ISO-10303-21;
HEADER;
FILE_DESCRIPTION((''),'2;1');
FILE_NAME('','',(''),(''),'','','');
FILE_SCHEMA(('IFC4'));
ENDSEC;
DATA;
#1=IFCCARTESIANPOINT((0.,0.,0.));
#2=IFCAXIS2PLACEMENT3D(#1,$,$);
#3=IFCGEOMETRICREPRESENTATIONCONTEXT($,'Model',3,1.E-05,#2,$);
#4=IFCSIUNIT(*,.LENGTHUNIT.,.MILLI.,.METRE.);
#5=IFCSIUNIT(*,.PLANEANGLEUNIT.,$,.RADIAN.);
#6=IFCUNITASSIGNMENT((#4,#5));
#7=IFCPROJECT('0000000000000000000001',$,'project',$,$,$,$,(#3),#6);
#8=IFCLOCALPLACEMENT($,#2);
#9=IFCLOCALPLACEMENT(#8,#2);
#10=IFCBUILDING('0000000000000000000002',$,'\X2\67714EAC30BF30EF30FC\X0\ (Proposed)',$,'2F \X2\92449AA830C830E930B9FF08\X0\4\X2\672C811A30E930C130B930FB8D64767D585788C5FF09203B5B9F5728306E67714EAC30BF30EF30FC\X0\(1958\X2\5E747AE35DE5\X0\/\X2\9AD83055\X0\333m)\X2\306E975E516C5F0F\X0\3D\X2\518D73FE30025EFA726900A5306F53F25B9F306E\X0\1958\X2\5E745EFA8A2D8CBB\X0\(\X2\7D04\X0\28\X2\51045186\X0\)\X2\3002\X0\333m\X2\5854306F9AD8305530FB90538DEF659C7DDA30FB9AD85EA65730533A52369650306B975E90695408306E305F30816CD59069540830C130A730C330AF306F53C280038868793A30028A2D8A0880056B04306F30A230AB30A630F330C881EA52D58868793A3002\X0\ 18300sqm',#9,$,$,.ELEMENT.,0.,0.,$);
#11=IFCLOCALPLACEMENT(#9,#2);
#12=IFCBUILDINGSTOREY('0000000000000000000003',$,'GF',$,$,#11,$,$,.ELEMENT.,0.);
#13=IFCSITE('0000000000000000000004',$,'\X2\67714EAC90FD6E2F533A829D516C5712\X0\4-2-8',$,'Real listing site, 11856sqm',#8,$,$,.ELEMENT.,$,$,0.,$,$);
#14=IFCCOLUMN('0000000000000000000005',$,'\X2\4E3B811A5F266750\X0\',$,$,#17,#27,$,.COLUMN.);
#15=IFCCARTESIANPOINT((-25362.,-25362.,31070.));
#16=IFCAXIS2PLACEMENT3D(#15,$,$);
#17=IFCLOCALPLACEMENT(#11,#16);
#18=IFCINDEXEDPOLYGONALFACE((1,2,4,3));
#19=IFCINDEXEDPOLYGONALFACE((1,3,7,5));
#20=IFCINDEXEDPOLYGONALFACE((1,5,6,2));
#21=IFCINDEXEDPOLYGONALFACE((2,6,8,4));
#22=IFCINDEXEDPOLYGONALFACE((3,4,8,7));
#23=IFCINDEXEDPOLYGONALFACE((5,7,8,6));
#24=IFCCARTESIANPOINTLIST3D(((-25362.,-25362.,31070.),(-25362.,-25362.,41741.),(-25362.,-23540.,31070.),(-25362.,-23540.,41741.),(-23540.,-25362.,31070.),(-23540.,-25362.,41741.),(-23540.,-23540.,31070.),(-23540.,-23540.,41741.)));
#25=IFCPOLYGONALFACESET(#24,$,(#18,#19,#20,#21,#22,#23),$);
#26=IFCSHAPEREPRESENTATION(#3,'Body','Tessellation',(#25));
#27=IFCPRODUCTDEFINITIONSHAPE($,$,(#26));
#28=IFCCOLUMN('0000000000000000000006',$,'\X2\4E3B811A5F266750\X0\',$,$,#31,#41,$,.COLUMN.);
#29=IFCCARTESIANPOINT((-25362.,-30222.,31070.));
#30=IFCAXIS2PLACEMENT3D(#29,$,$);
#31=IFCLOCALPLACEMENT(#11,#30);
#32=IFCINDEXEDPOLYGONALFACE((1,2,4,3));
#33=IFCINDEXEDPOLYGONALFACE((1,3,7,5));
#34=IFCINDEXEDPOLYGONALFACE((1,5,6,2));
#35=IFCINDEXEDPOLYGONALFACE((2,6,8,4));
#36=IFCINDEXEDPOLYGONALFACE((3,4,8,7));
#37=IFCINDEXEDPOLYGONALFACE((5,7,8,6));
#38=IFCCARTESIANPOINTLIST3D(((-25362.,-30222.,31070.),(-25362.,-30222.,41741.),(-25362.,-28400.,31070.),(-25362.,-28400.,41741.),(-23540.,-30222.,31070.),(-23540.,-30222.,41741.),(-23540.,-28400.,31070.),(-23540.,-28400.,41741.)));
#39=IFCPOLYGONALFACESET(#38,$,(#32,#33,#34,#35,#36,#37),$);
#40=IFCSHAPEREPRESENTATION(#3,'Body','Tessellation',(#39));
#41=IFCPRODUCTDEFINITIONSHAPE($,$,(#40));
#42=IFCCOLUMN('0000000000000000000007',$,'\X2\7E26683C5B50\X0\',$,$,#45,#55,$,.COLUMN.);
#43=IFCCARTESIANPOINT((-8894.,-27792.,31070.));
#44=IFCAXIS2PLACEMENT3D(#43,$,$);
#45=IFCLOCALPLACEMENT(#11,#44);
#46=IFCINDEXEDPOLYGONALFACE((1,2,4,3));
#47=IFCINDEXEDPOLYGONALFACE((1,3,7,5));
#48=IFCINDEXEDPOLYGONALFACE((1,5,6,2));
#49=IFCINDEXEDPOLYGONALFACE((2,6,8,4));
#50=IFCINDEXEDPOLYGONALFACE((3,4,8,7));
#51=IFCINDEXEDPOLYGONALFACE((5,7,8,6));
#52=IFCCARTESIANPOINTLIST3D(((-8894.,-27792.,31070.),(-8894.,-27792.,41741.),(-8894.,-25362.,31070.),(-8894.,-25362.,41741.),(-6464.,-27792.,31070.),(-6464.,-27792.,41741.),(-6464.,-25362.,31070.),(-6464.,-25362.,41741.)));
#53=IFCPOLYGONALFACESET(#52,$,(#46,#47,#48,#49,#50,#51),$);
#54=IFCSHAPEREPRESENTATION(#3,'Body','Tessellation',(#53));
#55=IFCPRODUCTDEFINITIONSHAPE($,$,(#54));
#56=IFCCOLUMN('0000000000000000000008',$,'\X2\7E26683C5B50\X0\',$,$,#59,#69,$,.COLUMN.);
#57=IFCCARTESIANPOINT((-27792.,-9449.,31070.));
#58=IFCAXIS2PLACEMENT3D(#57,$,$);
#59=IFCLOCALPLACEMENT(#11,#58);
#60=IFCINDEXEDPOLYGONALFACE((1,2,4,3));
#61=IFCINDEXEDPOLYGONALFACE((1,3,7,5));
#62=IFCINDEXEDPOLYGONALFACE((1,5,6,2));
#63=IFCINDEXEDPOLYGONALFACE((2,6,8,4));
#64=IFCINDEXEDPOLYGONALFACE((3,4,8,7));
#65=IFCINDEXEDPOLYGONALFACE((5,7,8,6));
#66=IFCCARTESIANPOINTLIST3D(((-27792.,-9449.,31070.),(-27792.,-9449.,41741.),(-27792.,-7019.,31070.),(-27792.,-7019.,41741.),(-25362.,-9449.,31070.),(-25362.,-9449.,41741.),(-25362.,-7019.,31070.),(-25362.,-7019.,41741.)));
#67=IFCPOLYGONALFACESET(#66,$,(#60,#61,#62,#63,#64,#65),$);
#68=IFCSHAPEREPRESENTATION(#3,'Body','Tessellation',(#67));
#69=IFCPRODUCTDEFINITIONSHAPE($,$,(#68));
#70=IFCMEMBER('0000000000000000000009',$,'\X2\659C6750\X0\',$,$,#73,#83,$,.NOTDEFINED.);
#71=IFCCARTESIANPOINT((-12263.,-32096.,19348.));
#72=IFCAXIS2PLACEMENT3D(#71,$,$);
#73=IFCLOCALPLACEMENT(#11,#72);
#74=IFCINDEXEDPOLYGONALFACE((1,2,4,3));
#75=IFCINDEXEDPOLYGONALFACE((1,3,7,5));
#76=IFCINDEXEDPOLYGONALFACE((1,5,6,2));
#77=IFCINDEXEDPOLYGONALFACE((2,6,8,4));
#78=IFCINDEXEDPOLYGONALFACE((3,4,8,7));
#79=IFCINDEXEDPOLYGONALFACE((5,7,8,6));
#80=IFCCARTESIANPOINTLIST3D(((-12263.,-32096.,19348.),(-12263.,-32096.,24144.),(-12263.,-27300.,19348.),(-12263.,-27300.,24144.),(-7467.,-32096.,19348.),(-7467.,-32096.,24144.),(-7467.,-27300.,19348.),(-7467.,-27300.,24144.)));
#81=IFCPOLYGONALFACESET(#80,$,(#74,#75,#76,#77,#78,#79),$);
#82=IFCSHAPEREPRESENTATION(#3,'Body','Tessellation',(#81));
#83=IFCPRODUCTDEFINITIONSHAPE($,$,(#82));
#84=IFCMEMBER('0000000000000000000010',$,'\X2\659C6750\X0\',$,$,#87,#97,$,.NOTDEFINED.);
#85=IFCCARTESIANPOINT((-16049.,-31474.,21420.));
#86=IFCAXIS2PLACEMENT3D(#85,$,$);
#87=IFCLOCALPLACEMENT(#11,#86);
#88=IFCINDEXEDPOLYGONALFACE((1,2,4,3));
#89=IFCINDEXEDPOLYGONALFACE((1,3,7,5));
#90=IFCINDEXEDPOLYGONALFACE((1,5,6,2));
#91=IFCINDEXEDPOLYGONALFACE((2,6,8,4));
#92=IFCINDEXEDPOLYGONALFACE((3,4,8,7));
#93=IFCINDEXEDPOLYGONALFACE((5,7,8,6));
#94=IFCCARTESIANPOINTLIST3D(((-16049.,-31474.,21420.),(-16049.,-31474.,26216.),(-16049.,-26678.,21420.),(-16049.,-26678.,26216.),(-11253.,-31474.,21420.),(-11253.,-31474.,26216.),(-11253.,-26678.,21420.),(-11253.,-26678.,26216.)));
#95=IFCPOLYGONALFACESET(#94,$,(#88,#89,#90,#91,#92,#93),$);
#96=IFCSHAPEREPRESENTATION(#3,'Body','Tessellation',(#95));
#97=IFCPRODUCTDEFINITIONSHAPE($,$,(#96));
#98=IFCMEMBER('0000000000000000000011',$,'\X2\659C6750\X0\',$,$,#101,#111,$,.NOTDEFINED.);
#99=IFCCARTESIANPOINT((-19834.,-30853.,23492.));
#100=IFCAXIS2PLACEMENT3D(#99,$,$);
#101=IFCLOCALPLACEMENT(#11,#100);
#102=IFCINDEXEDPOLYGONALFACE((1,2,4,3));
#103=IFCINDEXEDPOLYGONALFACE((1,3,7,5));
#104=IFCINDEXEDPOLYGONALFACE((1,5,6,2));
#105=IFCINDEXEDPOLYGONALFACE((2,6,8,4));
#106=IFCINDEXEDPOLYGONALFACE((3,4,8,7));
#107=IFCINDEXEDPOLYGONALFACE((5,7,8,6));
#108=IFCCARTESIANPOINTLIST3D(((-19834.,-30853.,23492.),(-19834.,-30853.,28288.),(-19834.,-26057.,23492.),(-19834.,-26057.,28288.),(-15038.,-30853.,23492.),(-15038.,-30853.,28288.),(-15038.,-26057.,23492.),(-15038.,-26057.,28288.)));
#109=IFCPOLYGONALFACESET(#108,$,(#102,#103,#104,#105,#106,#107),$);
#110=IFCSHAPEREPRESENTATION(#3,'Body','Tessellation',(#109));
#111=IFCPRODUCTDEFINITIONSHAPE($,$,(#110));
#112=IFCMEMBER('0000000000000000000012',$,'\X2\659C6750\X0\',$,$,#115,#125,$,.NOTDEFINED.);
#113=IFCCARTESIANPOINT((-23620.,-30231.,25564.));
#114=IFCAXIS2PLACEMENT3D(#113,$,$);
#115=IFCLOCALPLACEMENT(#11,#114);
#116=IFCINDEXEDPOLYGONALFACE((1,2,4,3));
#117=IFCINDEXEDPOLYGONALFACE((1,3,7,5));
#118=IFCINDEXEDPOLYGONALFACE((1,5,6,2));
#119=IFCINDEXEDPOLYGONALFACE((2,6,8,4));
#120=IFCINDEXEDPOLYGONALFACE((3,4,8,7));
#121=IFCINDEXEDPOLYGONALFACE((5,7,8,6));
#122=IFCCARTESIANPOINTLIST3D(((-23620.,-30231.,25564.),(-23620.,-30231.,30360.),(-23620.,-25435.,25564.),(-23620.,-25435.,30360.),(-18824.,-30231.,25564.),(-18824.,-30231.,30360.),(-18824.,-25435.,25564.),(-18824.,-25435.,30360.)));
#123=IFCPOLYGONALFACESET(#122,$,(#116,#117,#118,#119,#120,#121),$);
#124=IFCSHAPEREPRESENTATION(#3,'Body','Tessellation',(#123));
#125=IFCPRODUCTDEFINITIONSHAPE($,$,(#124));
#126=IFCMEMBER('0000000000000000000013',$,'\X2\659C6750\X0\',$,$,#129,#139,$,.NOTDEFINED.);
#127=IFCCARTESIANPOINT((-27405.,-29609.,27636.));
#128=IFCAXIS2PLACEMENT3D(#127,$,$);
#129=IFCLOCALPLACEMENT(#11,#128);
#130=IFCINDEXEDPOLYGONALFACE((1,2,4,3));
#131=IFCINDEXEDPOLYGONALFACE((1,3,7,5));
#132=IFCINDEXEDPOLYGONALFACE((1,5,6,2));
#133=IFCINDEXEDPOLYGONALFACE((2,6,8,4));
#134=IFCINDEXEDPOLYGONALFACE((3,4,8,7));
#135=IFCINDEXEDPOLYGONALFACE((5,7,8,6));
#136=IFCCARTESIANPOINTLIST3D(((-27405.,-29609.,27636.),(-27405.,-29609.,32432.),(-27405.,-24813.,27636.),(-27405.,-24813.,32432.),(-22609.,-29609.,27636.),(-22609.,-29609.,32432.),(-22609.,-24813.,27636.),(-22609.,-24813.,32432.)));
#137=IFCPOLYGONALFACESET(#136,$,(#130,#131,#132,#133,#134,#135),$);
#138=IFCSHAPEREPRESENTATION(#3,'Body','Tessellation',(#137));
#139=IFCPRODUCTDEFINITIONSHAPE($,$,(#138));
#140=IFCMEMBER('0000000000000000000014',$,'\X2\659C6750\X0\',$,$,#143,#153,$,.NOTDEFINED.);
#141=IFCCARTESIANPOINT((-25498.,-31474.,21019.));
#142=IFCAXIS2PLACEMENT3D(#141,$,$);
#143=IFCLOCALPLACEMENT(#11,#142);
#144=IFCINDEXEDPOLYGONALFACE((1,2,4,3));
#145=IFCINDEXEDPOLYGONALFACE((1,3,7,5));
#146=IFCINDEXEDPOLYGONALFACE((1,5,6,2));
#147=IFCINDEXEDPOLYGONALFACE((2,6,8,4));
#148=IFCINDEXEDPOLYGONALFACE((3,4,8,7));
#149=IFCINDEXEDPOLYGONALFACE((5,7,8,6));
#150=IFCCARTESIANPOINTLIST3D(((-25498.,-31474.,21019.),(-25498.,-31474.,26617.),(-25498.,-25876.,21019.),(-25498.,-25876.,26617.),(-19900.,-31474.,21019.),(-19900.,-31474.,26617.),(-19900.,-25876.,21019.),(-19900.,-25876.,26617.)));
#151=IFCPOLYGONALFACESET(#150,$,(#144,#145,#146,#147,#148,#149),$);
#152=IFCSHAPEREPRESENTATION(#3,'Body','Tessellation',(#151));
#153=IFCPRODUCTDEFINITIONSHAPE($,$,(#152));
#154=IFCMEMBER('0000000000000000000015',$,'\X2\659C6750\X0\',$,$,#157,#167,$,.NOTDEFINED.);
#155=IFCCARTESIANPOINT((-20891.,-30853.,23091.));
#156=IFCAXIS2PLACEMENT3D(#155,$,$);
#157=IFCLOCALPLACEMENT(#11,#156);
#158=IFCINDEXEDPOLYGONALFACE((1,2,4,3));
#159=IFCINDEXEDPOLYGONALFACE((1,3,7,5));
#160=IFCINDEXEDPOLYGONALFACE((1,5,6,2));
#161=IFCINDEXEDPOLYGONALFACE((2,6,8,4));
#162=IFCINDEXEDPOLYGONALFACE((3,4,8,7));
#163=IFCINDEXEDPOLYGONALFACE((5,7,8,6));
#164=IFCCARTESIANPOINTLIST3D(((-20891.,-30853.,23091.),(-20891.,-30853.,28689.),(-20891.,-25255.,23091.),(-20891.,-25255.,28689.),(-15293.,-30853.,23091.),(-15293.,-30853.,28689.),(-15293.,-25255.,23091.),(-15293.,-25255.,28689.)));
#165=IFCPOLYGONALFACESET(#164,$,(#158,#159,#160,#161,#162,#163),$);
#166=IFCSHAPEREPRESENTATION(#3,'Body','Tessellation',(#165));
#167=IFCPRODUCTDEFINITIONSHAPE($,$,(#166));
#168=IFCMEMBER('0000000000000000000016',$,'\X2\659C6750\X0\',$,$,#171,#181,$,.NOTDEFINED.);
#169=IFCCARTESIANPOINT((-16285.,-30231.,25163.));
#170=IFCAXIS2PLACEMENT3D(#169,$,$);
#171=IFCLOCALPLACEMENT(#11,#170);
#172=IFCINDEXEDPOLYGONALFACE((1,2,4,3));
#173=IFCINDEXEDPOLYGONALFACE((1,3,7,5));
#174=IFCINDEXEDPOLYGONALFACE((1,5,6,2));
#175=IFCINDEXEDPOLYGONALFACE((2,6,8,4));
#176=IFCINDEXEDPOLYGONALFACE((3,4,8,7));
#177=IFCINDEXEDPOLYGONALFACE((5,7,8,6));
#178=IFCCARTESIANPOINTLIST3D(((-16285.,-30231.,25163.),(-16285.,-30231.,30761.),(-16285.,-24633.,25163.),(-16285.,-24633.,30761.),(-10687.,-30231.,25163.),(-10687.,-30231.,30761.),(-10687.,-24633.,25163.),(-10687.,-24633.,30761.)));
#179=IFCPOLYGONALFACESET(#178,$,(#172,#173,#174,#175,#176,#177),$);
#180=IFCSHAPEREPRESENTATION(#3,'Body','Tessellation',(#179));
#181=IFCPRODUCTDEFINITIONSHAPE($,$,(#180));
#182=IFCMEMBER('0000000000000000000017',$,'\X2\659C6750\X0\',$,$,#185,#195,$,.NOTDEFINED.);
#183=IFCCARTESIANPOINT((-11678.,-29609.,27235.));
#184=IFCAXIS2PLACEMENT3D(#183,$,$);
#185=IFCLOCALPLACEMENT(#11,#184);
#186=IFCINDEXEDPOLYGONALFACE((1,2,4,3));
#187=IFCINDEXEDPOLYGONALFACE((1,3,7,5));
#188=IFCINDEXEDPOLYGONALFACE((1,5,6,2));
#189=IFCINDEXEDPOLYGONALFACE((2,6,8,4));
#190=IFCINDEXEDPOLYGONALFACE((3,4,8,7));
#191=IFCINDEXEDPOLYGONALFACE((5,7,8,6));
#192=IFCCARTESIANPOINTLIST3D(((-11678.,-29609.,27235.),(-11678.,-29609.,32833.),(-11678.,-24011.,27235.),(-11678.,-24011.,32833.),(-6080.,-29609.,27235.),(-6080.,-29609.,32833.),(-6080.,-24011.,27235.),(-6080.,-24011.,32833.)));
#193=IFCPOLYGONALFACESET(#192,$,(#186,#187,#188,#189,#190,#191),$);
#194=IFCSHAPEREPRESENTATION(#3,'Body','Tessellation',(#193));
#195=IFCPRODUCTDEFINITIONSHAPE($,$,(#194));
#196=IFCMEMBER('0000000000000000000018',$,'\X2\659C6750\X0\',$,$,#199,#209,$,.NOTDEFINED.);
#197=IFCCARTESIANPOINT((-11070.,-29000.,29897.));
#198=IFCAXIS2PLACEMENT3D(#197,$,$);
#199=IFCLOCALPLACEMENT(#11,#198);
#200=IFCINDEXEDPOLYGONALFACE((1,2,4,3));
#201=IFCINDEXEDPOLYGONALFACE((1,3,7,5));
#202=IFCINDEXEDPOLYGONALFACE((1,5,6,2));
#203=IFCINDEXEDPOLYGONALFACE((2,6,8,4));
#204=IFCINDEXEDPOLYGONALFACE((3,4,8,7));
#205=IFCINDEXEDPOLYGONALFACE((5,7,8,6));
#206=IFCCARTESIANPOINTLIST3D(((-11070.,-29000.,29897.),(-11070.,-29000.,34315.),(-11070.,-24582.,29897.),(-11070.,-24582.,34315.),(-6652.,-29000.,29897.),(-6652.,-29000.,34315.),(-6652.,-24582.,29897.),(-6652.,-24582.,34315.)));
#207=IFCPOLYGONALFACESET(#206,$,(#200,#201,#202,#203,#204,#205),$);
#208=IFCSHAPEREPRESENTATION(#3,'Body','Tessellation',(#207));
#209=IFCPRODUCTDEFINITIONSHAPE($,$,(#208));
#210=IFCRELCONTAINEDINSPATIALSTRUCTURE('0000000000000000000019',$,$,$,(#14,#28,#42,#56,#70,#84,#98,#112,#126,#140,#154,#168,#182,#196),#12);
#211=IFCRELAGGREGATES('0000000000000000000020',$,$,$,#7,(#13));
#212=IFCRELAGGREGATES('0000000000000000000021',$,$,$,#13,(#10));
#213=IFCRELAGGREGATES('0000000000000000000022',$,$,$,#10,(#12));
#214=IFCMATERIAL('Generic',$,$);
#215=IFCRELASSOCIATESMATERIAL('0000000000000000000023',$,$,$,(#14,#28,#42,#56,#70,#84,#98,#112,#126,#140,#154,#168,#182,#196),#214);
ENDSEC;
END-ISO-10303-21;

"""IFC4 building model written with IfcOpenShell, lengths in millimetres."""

from ifc_helpers import new_model, si_unit, frame, frame_2d, origin, place, context, project, spatial, rectangle, extrude, material, element, save


model = new_model("IFC4")

# Units and contexts
model_context = context("Model", 3, precision=1e-05, world=origin())
ifc_project = project(units=[si_unit("LENGTHUNIT", "METRE", prefix="MILLI"), si_unit("PLANEANGLEUNIT", "RADIAN")], contexts=[model_context])

# Site, building, storey
site_placement = place(None, origin())
site = spatial("IfcSite", under=ifc_project, at=site_placement, Name="東京都港区芝公園4-2-8", ObjectType="Real listing site, 11856sqm", CompositionType="ELEMENT", RefElevation=0.0)
building_placement = place(site_placement, origin())
building = spatial("IfcBuilding", under=site, at=building_placement, Name="東京タワー (Proposed)", ObjectType="2F 鉄骨トラス（4本脚ラチス・赤白塗装）※実在の東京タワー(1958年竣工/高さ333m)の非公式3D再現。建物¥は史実の1958年建設費(約28億円)。333m塔は高さ・道路斜線・高度地区制限に非適合のため法適合チェックは参考表示。設計者欄はアカウント自動表示。 18300sqm", CompositionType="ELEMENT", ElevationOfRefHeight=0.0, ElevationOfTerrain=0.0)
storey_placement = place(building_placement, origin())
storey = spatial("IfcBuildingStorey", under=building, at=storey_placement, Name="GF", CompositionType="ELEMENT", Elevation=0.0)

# Columns
ifc_material = material(Name="Generic")
column_1_placement = place(storey_placement, frame((-25362.0, -25362.0, 31070.0)))
element("IfcColumn", 1, at=column_1_placement, inside=storey, material=ifc_material, Name="主脚弦材", PredefinedType="COLUMN", context=model_context, shape_type="SweptSolid", body=[
    extrude(rectangle(XDim=1822.0, YDim=1822.0, at=frame_2d((911.0, 911.0))), frame((-25362.0, -25362.0, 31070.0)), (0.0, 0.0, 1.0), 10671.0),
])
column_2_placement = place(storey_placement, frame((-25362.0, -30222.0, 31070.0)))
element("IfcColumn", 2, at=column_2_placement, inside=storey, material=ifc_material, Name="主脚弦材", PredefinedType="COLUMN", context=model_context, shape_type="SweptSolid", body=[
    extrude(rectangle(XDim=1822.0, YDim=1822.0, at=frame_2d((911.0, 911.0))), frame((-25362.0, -30222.0, 31070.0)), (0.0, 0.0, 1.0), 10671.0),
])
column_3_placement = place(storey_placement, frame((-8894.0, -27792.0, 31070.0)))
element("IfcColumn", 3, at=column_3_placement, inside=storey, material=ifc_material, Name="縦格子", PredefinedType="COLUMN", context=model_context, shape_type="SweptSolid", body=[
    extrude(rectangle(XDim=2430.0, YDim=2430.0, at=frame_2d((1215.0, 1215.0))), frame((-8894.0, -27792.0, 31070.0)), (0.0, 0.0, 1.0), 10671.0),
])
column_4_placement = place(storey_placement, frame((-27792.0, -9449.0, 31070.0)))
element("IfcColumn", 4, at=column_4_placement, inside=storey, material=ifc_material, Name="縦格子", PredefinedType="COLUMN", context=model_context, shape_type="SweptSolid", body=[
    extrude(rectangle(XDim=2430.0, YDim=2430.0, at=frame_2d((1215.0, 1215.0))), frame((-27792.0, -9449.0, 31070.0)), (0.0, 0.0, 1.0), 10671.0),
])

# Members
member_1_placement = place(storey_placement, frame((-12263.0, -32096.0, 19348.0)))
element("IfcMember", 5, at=member_1_placement, inside=storey, material=ifc_material, Name="斜材", PredefinedType="NOTDEFINED", context=model_context, shape_type="SweptSolid", body=[
    extrude(rectangle(XDim=4796.0, YDim=4796.0, at=frame_2d((2398.0, 2398.0))), frame((-12263.0, -32096.0, 19348.0)), (0.0, 0.0, 1.0), 4796.0),
])
member_2_placement = place(storey_placement, frame((-16049.0, -31474.0, 21420.0)))
element("IfcMember", 6, at=member_2_placement, inside=storey, material=ifc_material, Name="斜材", PredefinedType="NOTDEFINED", context=model_context, shape_type="SweptSolid", body=[
    extrude(rectangle(XDim=4796.0, YDim=4796.0, at=frame_2d((2398.0, 2398.0))), frame((-16049.0, -31474.0, 21420.0)), (0.0, 0.0, 1.0), 4796.0),
])
member_3_placement = place(storey_placement, frame((-19834.0, -30853.0, 23492.0)))
element("IfcMember", 7, at=member_3_placement, inside=storey, material=ifc_material, Name="斜材", PredefinedType="NOTDEFINED", context=model_context, shape_type="SweptSolid", body=[
    extrude(rectangle(XDim=4796.0, YDim=4796.0, at=frame_2d((2398.0, 2398.0))), frame((-19834.0, -30853.0, 23492.0)), (0.0, 0.0, 1.0), 4796.0),
])
member_4_placement = place(storey_placement, frame((-23620.0, -30231.0, 25564.0)))
element("IfcMember", 8, at=member_4_placement, inside=storey, material=ifc_material, Name="斜材", PredefinedType="NOTDEFINED", context=model_context, shape_type="SweptSolid", body=[
    extrude(rectangle(XDim=4796.0, YDim=4796.0, at=frame_2d((2398.0, 2398.0))), frame((-23620.0, -30231.0, 25564.0)), (0.0, 0.0, 1.0), 4796.0),
])
member_5_placement = place(storey_placement, frame((-27405.0, -29609.0, 27636.0)))
element("IfcMember", 9, at=member_5_placement, inside=storey, material=ifc_material, Name="斜材", PredefinedType="NOTDEFINED", context=model_context, shape_type="SweptSolid", body=[
    extrude(rectangle(XDim=4796.0, YDim=4796.0, at=frame_2d((2398.0, 2398.0))), frame((-27405.0, -29609.0, 27636.0)), (0.0, 0.0, 1.0), 4796.0),
])
member_6_placement = place(storey_placement, frame((-25498.0, -31474.0, 21019.0)))
element("IfcMember", 10, at=member_6_placement, inside=storey, material=ifc_material, Name="斜材", PredefinedType="NOTDEFINED", context=model_context, shape_type="SweptSolid", body=[
    extrude(rectangle(XDim=5598.0, YDim=5598.0, at=frame_2d((2799.0, 2799.0))), frame((-25498.0, -31474.0, 21019.0)), (0.0, 0.0, 1.0), 5598.0),
])
member_7_placement = place(storey_placement, frame((-20891.0, -30853.0, 23091.0)))
element("IfcMember", 11, at=member_7_placement, inside=storey, material=ifc_material, Name="斜材", PredefinedType="NOTDEFINED", context=model_context, shape_type="SweptSolid", body=[
    extrude(rectangle(XDim=5598.0, YDim=5598.0, at=frame_2d((2799.0, 2799.0))), frame((-20891.0, -30853.0, 23091.0)), (0.0, 0.0, 1.0), 5598.0),
])
member_8_placement = place(storey_placement, frame((-16285.0, -30231.0, 25163.0)))
element("IfcMember", 12, at=member_8_placement, inside=storey, material=ifc_material, Name="斜材", PredefinedType="NOTDEFINED", context=model_context, shape_type="SweptSolid", body=[
    extrude(rectangle(XDim=5598.0, YDim=5598.0, at=frame_2d((2799.0, 2799.0))), frame((-16285.0, -30231.0, 25163.0)), (0.0, 0.0, 1.0), 5598.0),
])
member_9_placement = place(storey_placement, frame((-11678.0, -29609.0, 27235.0)))
element("IfcMember", 13, at=member_9_placement, inside=storey, material=ifc_material, Name="斜材", PredefinedType="NOTDEFINED", context=model_context, shape_type="SweptSolid", body=[
    extrude(rectangle(XDim=5598.0, YDim=5598.0, at=frame_2d((2799.0, 2799.0))), frame((-11678.0, -29609.0, 27235.0)), (0.0, 0.0, 1.0), 5598.0),
])
member_10_placement = place(storey_placement, frame((-11070.0, -29000.0, 29897.0)))
element("IfcMember", 14, at=member_10_placement, inside=storey, material=ifc_material, Name="斜材", PredefinedType="NOTDEFINED", context=model_context, shape_type="SweptSolid", body=[
    extrude(rectangle(XDim=4418.0, YDim=4418.0, at=frame_2d((2209.0, 2209.0))), frame((-11070.0, -29000.0, 29897.0)), (0.0, 0.0, 1.0), 4418.0),
])

save(model, "model.ifc")
